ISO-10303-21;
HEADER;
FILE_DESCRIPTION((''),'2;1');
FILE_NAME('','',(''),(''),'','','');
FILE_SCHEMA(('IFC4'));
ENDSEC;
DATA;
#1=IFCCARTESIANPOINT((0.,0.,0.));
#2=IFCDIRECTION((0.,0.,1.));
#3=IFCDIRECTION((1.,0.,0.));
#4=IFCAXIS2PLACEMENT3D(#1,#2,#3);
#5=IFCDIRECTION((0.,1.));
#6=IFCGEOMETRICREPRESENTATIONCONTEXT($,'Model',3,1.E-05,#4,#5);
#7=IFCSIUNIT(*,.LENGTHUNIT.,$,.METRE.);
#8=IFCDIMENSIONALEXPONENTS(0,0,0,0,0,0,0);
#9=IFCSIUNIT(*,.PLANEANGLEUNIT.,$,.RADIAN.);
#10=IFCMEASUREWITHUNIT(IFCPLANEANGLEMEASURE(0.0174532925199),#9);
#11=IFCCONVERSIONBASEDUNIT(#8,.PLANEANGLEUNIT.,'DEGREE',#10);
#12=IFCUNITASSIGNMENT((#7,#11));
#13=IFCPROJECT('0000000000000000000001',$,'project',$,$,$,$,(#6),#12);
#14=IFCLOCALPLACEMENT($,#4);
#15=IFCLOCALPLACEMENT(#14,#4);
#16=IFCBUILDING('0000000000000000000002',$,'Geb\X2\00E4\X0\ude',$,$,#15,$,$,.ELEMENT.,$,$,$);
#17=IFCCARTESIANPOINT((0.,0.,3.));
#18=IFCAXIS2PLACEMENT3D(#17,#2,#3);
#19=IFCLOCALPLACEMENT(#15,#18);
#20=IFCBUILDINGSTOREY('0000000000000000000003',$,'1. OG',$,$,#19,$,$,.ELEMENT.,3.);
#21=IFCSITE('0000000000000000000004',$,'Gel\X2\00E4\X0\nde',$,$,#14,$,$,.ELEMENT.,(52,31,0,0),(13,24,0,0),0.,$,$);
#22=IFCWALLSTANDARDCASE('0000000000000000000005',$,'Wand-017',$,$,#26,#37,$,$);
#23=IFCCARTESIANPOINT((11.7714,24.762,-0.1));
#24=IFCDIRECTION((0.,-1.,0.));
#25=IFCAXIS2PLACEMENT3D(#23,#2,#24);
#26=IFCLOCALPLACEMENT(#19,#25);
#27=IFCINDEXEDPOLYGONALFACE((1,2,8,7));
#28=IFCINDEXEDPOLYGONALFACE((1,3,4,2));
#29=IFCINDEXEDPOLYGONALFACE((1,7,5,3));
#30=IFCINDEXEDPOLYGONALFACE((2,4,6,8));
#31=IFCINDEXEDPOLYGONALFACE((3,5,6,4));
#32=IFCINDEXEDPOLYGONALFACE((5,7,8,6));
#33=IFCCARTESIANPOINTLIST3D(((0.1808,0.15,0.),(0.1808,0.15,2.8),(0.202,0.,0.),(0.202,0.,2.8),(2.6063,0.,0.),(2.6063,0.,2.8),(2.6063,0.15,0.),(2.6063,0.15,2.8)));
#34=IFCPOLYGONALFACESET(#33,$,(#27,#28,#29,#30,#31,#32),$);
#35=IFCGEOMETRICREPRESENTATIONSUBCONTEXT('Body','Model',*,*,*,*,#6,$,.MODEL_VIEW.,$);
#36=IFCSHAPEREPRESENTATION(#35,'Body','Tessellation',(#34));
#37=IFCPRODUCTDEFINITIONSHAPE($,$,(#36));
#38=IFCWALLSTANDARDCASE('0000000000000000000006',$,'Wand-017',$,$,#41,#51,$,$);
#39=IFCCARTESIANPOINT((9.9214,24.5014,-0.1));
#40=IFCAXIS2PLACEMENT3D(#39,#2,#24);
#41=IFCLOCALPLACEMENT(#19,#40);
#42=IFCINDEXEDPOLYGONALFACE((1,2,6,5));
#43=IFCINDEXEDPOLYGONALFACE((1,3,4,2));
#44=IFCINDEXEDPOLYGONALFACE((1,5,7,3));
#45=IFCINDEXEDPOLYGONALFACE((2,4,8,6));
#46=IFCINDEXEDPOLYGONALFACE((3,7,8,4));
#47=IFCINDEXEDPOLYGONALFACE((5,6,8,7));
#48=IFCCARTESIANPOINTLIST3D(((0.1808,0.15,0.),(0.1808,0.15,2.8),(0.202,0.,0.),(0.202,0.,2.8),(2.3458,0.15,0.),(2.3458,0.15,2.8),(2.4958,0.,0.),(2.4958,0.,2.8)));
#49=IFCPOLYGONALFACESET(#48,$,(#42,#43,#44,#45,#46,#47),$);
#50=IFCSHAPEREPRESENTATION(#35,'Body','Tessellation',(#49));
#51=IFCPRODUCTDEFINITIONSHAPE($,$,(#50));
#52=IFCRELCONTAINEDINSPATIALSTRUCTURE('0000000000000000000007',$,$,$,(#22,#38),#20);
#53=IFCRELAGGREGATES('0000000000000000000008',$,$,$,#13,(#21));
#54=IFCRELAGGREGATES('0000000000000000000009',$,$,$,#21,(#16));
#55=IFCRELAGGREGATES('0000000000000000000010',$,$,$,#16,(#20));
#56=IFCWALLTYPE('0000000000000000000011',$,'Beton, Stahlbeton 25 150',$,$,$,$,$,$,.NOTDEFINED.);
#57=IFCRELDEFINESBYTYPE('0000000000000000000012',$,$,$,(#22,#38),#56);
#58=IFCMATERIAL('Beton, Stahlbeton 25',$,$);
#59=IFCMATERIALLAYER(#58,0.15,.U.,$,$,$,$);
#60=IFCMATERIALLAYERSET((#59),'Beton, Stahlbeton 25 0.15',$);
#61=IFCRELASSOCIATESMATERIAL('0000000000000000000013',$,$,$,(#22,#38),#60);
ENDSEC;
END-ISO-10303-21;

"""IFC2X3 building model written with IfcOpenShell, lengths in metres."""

from ifc_helpers import new_model, entity, si_unit, converted_unit, direction, frame, origin_with_axes, place, context, subcontext, project, spatial, polyline, outline, extrude, material, layer, layer_set, layer_usage, type_object, element, save


model = new_model("IFC2X3")

# Units and contexts
model_context = context("Model", 3, precision=1e-05, world=origin_with_axes(), true_north=direction((0.0, 1.0)))
body_context = subcontext(model_context, "Body", "Model", "MODEL_VIEW")
ifc_project = project(units=[si_unit("LENGTHUNIT", "METRE"), converted_unit("PLANEANGLEUNIT", "DEGREE", entity("IfcPlaneAngleMeasure", 0.0174532925199), si_unit("PLANEANGLEUNIT", "RADIAN"), dimensions=[0, 0, 0, 0, 0, 0, 0])], contexts=[model_context])

# Site, building, storey
site_placement = place(None, origin_with_axes())
site = spatial("IfcSite", under=ifc_project, at=site_placement, Name="Gelände", CompositionType="ELEMENT", RefLatitude=(52, 31, 0, 0), RefLongitude=(13, 24, 0, 0), RefElevation=0.0)
building_placement = place(site_placement, origin_with_axes())
building = spatial("IfcBuilding", under=site, at=building_placement, Name="Gebäude", CompositionType="ELEMENT")
storey_placement = place(building_placement, frame((0.0, 0.0, 3.0), z_axis=(0.0, 0.0, 1.0), x_axis=(1.0, 0.0, 0.0)))
storey = spatial("IfcBuildingStorey", under=building, at=storey_placement, Name="1. OG", CompositionType="ELEMENT", Elevation=3.0)

# Walls
ifc_material = material(Name="Beton, Stahlbeton 25")
ifc_layer_1 = layer(ifc_material, 0.15, ventilated="UNKNOWN")
ifc_layer_set_1 = layer_set([ifc_layer_1], Name="Beton, Stahlbeton 25 0.15")
wall_type_1 = type_object("IfcWallType", Name="Beton, Stahlbeton 25 150", PredefinedType="NOTDEFINED")
ifc_layer_usage_1 = layer_usage(ifc_layer_set_1, "AXIS2", "POSITIVE", 0.0)
wall_1_placement = place(storey_placement, frame((11.7714, 24.762, -0.1), z_axis=(0.0, 0.0, 1.0), x_axis=(0.0, -1.0, 0.0)))
element("IfcWallStandardCase", 1, at=wall_1_placement, inside=storey, type_object=wall_type_1, material=ifc_layer_usage_1, Name="Wand-017", context=body_context, shape_type="SweptSolid", body=[
    extrude(outline(polyline([(0.202, 0.0), (2.6063, 0.0), (2.6063, 0.15), (0.1808, 0.15), (0.202, 0.0)])), origin_with_axes(), (0.0, 0.0, 1.0), 2.8),
])
ifc_layer_usage_2 = layer_usage(ifc_layer_set_1, "AXIS2", "POSITIVE", 0.0)
wall_2_placement = place(storey_placement, frame((9.9214, 24.5014, -0.1), z_axis=(0.0, 0.0, 1.0), x_axis=(0.0, -1.0, 0.0)))
element("IfcWallStandardCase", 2, at=wall_2_placement, inside=storey, type_object=wall_type_1, material=ifc_layer_usage_2, Name="Wand-017", context=body_context, shape_type="SweptSolid", body=[
    extrude(outline(polyline([(0.202, 0.0), (2.4958, 0.0), (2.3458, 0.15), (0.1808, 0.15), (0.202, 0.0)])), origin_with_axes(), (0.0, 0.0, 1.0), 2.8),
])

save(model, "model.ifc")
